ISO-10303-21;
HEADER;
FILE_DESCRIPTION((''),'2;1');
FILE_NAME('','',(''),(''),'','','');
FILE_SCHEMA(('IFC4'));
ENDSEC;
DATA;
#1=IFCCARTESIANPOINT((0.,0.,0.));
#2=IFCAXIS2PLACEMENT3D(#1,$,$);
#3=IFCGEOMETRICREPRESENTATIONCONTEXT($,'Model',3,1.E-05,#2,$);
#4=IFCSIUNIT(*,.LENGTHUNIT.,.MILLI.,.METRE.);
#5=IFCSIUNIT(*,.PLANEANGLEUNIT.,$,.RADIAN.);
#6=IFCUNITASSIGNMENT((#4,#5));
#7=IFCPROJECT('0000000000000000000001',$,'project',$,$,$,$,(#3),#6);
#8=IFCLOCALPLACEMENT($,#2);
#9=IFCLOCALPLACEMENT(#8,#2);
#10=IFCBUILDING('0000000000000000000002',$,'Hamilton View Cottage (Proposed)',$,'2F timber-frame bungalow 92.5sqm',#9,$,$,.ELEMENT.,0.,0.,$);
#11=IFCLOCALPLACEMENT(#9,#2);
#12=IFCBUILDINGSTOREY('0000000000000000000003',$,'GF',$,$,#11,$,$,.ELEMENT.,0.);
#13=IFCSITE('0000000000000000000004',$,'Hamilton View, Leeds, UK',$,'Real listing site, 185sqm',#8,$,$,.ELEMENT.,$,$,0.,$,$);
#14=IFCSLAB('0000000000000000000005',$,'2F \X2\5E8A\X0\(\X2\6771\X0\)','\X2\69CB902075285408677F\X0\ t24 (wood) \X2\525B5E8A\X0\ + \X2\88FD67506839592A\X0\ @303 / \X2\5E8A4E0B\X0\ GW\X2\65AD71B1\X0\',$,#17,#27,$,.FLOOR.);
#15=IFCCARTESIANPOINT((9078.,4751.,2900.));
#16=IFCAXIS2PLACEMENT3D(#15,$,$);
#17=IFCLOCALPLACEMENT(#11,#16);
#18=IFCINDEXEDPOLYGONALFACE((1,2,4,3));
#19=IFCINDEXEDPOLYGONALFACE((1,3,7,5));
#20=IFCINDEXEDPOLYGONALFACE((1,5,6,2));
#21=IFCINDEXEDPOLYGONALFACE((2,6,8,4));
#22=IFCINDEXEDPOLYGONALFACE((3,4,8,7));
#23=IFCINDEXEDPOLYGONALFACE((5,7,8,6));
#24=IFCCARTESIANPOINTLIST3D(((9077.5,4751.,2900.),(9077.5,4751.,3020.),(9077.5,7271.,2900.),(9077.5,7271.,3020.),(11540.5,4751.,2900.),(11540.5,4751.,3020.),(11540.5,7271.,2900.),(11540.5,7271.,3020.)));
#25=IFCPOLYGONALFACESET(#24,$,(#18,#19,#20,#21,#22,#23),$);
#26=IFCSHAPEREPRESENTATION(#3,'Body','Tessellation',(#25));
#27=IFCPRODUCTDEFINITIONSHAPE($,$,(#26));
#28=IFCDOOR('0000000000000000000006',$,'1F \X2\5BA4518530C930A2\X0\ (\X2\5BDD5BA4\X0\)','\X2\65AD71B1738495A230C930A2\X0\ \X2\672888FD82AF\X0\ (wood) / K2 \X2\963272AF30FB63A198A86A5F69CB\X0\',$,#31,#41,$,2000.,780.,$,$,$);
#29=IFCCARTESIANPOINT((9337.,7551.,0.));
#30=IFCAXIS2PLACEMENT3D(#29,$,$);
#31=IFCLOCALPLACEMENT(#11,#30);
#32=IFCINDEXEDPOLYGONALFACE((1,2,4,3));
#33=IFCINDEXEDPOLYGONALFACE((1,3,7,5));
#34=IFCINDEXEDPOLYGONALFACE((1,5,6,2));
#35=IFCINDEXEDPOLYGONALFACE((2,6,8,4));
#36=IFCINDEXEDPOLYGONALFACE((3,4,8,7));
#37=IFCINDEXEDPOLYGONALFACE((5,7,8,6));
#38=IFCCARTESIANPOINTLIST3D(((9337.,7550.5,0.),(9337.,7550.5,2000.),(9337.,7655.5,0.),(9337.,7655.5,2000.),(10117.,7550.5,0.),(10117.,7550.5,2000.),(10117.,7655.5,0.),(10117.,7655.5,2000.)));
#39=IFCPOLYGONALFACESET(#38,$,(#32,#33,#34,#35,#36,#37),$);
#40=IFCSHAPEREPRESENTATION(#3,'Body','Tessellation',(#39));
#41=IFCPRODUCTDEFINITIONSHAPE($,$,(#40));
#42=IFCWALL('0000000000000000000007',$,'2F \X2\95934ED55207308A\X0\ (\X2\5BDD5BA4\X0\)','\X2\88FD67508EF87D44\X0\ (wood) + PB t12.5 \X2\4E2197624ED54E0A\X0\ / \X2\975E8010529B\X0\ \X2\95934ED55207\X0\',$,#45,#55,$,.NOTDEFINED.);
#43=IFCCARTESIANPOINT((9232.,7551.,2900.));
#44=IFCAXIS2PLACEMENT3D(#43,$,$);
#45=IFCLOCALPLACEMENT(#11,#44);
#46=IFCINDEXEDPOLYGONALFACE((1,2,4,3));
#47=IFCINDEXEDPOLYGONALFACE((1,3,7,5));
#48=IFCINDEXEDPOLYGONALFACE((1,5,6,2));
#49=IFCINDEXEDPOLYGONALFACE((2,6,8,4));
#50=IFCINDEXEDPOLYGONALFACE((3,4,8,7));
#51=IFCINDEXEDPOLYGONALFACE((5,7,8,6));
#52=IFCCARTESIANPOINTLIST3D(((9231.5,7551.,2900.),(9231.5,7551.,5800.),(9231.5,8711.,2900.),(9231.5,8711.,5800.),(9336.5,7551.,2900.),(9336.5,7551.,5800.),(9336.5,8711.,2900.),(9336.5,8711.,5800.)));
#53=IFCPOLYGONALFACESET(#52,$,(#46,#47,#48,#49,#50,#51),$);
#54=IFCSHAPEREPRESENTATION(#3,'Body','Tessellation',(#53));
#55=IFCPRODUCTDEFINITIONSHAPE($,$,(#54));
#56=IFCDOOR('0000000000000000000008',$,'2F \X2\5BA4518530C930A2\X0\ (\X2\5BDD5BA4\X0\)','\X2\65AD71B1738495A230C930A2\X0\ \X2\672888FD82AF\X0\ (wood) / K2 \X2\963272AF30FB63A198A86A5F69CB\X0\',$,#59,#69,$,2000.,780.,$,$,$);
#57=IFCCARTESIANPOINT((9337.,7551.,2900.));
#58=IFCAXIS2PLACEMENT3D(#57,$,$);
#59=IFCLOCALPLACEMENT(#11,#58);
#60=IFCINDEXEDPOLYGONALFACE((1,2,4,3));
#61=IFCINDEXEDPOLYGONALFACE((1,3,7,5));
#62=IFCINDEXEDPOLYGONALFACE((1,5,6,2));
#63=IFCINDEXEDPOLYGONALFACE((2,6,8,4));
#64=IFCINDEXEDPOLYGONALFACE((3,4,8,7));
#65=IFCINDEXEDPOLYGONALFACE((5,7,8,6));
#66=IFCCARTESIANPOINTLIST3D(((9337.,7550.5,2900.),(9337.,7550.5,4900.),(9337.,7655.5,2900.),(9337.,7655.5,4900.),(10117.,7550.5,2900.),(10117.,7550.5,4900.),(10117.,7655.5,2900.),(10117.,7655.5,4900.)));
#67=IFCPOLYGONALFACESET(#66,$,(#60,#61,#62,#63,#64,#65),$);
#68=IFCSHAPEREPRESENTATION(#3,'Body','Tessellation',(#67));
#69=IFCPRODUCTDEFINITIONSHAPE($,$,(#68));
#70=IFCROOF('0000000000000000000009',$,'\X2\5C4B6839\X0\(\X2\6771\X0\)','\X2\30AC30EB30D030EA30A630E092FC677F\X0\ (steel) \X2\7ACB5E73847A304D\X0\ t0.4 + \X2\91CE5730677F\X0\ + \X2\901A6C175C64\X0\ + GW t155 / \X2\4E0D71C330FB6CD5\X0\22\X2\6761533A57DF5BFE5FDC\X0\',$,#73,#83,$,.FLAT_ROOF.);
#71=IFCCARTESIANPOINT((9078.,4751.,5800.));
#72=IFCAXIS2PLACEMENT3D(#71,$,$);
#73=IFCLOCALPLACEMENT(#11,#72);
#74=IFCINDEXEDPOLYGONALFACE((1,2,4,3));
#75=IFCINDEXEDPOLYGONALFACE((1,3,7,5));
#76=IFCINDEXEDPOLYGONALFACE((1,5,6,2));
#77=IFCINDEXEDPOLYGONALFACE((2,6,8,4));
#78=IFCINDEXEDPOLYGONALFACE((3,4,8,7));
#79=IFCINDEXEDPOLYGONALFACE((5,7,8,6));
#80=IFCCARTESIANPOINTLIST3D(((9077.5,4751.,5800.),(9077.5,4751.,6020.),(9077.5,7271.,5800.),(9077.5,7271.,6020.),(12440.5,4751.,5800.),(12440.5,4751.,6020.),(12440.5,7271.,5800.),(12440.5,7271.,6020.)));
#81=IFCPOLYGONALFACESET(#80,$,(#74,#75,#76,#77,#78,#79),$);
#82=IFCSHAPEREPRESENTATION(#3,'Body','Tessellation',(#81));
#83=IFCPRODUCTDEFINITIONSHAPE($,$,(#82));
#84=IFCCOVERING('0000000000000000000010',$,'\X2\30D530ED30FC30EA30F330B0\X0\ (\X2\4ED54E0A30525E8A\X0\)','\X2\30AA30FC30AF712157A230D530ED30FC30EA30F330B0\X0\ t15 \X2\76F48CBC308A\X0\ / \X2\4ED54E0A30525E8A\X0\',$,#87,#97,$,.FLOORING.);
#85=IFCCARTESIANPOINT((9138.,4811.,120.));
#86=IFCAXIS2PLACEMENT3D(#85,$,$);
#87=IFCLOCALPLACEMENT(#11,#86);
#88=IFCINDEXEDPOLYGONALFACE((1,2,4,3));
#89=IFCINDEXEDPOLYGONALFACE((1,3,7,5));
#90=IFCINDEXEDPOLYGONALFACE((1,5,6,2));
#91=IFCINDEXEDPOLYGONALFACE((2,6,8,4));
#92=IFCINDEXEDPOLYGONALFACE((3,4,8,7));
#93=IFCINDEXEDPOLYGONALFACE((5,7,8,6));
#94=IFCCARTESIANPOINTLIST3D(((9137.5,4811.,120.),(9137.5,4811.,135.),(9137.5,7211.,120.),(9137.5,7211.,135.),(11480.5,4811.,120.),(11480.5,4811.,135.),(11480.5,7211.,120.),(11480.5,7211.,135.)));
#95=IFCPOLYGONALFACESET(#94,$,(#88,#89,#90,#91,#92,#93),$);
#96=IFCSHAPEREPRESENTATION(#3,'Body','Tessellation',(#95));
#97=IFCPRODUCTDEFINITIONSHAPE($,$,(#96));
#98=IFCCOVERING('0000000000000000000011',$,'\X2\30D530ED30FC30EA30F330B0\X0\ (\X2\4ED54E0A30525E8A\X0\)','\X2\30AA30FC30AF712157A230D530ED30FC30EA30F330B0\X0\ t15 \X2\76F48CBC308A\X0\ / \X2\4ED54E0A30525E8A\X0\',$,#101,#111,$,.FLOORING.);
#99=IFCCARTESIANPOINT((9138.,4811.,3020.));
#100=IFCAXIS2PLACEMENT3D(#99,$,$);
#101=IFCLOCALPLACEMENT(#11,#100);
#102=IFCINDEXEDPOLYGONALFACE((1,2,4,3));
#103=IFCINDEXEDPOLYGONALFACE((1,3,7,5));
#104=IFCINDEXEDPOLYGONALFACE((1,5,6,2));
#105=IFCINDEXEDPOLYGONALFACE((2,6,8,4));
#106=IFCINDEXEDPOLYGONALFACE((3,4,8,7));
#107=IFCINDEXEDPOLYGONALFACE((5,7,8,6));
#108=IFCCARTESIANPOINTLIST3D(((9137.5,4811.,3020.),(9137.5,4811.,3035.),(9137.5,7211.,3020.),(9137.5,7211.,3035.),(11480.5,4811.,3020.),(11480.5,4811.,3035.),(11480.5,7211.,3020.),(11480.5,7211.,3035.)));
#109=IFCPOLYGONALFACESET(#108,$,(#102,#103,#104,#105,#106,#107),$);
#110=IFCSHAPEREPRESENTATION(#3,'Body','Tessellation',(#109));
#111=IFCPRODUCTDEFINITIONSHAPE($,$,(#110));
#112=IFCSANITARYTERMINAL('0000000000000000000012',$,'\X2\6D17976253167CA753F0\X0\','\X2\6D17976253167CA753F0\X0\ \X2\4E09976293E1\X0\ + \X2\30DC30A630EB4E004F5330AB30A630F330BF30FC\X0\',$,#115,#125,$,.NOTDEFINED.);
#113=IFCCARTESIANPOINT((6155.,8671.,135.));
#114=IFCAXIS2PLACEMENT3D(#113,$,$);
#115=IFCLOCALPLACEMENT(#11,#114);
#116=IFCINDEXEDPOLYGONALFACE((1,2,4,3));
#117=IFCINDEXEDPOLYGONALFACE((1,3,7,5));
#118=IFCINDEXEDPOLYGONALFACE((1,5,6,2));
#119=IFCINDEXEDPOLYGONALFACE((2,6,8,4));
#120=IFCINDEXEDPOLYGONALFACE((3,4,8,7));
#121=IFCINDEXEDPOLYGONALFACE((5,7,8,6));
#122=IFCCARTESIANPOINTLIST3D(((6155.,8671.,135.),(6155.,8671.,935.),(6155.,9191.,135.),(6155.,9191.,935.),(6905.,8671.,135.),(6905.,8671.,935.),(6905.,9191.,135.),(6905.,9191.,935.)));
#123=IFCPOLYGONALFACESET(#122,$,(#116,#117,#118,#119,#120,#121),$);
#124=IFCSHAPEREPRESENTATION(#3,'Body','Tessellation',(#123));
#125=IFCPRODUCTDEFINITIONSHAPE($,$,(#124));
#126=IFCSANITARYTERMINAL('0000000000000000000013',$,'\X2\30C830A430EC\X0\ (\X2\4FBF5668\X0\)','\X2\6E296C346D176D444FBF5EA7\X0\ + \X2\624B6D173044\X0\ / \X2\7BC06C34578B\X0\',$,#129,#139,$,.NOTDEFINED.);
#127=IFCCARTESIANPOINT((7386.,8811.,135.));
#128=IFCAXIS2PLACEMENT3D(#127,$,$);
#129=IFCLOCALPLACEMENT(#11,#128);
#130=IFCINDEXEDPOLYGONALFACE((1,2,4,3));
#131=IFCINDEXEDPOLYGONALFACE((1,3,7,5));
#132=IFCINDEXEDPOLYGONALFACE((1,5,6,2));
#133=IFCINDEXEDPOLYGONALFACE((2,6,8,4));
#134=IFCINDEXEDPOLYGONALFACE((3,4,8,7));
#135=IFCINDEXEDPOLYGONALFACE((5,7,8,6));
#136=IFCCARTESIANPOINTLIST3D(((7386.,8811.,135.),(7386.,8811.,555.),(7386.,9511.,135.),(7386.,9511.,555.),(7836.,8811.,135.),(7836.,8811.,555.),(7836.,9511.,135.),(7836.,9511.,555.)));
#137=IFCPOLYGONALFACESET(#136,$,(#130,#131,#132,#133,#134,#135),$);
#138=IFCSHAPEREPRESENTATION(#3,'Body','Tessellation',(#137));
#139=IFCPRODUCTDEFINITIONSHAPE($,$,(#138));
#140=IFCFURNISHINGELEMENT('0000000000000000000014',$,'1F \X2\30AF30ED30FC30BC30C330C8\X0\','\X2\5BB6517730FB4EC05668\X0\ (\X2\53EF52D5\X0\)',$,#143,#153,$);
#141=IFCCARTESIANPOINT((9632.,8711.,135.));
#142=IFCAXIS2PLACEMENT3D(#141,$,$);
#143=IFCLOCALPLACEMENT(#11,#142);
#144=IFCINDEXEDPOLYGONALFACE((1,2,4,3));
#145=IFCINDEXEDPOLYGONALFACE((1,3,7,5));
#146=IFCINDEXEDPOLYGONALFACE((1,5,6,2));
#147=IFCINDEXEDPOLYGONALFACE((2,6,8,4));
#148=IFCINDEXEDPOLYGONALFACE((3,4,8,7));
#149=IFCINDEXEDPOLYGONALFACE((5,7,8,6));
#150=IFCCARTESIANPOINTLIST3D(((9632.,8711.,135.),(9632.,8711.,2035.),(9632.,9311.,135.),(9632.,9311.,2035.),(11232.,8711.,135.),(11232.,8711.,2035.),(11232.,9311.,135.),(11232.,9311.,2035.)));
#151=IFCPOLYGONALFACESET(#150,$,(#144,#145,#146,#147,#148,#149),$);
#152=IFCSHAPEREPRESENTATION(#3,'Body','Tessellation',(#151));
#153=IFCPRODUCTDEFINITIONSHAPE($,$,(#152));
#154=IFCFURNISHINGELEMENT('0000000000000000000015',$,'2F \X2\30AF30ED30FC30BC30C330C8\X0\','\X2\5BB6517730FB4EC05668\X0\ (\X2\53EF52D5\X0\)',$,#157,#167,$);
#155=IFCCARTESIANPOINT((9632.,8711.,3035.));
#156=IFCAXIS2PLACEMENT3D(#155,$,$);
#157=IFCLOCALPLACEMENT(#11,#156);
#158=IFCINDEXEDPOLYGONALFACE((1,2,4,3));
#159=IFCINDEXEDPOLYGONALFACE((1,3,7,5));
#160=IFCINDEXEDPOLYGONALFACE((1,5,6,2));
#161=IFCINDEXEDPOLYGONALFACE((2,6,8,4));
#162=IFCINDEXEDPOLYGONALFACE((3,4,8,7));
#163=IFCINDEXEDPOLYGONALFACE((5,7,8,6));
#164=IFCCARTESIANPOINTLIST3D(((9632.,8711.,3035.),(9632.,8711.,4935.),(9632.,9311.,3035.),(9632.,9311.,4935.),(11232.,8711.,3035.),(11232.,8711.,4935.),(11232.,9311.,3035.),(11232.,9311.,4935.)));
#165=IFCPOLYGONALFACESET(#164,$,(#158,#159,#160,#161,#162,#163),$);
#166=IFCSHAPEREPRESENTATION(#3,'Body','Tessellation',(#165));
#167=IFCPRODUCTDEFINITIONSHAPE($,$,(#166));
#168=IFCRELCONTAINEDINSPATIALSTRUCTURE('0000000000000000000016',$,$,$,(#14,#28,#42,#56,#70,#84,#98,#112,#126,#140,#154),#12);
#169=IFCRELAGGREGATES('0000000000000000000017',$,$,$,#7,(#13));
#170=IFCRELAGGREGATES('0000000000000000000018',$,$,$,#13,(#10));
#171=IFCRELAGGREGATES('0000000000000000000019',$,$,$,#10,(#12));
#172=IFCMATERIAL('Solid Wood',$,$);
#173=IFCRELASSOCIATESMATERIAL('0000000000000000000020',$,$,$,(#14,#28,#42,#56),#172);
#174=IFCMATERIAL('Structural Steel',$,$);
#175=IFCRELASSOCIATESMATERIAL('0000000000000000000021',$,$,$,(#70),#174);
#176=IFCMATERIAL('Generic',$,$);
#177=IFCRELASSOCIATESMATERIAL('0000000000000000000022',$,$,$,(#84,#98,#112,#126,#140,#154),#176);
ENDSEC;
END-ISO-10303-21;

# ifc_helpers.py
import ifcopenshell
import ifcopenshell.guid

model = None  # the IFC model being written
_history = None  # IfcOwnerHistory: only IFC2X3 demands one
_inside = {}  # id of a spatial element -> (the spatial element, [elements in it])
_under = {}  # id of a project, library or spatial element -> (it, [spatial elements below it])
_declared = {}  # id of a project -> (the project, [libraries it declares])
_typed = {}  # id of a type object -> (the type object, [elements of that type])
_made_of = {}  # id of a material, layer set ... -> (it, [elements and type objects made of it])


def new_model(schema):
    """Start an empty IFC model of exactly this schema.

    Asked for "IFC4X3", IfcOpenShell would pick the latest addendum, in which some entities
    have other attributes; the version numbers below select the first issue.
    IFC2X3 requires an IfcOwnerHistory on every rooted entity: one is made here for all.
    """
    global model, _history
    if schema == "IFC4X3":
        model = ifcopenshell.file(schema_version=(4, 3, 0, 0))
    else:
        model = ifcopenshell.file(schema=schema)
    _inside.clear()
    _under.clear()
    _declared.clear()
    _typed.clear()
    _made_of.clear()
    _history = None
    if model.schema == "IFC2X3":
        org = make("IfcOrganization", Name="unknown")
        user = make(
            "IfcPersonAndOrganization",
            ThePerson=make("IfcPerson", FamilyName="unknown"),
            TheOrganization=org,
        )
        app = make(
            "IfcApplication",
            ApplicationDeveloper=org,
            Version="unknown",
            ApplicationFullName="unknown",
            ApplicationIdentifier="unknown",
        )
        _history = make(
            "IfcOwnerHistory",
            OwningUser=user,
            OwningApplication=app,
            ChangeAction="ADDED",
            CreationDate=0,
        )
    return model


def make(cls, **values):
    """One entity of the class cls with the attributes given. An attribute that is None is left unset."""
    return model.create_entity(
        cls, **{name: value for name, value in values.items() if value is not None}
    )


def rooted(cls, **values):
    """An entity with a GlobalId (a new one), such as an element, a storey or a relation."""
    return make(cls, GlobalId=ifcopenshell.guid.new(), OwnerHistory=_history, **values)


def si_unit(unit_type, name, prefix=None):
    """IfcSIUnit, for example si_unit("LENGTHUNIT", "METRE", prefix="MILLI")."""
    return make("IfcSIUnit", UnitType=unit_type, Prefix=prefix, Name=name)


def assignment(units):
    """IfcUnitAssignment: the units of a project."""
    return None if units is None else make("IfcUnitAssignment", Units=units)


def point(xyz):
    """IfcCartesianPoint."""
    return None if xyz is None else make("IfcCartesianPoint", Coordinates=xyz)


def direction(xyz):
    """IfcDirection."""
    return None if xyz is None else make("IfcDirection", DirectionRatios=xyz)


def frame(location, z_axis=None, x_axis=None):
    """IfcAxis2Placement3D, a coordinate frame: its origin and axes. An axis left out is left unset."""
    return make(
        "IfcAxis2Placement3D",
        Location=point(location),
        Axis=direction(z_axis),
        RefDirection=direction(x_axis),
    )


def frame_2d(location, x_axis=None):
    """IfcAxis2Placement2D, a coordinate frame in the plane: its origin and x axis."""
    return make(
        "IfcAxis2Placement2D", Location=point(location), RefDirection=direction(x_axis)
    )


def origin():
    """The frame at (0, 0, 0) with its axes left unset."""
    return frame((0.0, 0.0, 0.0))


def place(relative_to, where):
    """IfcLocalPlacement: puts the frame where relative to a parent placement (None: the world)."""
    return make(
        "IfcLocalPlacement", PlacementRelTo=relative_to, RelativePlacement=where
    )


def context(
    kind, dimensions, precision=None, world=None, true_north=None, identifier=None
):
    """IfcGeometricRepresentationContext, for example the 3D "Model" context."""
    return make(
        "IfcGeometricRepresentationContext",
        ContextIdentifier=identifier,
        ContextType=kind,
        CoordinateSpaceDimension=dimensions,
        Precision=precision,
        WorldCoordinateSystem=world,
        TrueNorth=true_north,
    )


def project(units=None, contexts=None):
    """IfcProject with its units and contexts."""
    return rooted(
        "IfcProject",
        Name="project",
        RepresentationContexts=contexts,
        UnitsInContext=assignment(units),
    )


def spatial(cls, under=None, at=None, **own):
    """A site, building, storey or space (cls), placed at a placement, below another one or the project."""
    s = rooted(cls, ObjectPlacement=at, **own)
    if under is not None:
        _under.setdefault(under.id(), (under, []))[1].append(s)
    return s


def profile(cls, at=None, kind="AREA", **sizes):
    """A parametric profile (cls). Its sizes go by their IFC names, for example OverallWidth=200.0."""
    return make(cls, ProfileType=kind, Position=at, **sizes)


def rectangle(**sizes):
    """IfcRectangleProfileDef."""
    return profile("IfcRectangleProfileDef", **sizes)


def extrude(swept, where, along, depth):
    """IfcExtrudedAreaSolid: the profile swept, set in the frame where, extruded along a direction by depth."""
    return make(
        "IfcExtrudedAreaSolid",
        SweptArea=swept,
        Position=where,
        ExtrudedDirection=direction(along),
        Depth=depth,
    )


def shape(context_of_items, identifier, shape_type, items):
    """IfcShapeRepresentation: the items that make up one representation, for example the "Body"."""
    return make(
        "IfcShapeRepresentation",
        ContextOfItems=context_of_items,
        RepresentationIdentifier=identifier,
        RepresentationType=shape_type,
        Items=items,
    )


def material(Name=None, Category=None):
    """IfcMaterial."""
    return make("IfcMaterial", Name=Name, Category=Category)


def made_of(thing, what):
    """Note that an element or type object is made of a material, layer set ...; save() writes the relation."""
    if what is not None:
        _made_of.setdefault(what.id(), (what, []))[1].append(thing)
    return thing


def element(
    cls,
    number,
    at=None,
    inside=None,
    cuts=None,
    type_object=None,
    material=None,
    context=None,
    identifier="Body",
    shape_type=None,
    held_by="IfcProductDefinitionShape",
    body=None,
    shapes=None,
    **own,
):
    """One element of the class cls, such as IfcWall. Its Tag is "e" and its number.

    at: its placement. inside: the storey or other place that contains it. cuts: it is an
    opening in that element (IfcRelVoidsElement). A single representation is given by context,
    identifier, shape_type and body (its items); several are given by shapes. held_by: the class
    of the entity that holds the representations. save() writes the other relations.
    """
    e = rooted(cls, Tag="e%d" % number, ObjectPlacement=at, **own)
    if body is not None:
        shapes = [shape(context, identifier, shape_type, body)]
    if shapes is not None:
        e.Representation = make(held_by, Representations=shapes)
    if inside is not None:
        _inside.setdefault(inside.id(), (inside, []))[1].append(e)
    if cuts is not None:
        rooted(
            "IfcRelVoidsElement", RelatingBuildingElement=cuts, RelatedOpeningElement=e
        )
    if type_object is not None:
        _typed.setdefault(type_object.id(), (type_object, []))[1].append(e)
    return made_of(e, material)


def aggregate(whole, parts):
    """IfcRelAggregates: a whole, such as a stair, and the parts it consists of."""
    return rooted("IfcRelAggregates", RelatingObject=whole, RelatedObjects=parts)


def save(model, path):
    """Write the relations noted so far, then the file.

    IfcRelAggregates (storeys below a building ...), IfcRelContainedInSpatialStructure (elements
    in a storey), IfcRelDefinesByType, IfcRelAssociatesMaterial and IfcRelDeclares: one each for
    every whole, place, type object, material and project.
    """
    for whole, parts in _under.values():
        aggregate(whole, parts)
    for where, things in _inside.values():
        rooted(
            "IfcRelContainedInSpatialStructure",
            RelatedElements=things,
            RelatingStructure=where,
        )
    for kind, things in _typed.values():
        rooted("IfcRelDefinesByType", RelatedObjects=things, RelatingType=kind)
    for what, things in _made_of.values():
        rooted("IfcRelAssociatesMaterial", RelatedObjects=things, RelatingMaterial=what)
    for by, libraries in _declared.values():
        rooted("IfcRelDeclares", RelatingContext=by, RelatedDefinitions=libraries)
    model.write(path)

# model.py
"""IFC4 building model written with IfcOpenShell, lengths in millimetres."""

from ifc_helpers import new_model, si_unit, frame, frame_2d, origin, place, context, project, spatial, rectangle, extrude, material, element, save


model = new_model("IFC4")

# Units and contexts
model_context = context("Model", 3, precision=1e-05, world=origin())
ifc_project = project(units=[si_unit("LENGTHUNIT", "METRE", prefix="MILLI"), si_unit("PLANEANGLEUNIT", "RADIAN")], contexts=[model_context])

# Site, building, storey
site_placement = place(None, origin())
site = spatial("IfcSite", under=ifc_project, at=site_placement, Name="Hamilton View, Leeds, UK", ObjectType="Real listing site, 185sqm", CompositionType="ELEMENT", RefElevation=0.0)
building_placement = place(site_placement, origin())
building = spatial("IfcBuilding", under=site, at=building_placement, Name="Hamilton View Cottage (Proposed)", ObjectType="2F timber-frame bungalow 92.5sqm", CompositionType="ELEMENT", ElevationOfRefHeight=0.0, ElevationOfTerrain=0.0)
storey_placement = place(building_placement, origin())
storey = spatial("IfcBuildingStorey", under=building, at=storey_placement, Name="GF", CompositionType="ELEMENT", Elevation=0.0)

# Slab
ifc_material_1 = material(Name="Solid Wood")
slab_1_placement = place(storey_placement, frame((9078.0, 4751.0, 2900.0)))
element("IfcSlab", 1, at=slab_1_placement, inside=storey, material=ifc_material_1, Name="2F 床(東)", Description="構造用合板 t24 (wood) 剛床 + 製材根太 @303 / 床下 GW断熱", PredefinedType="FLOOR", context=model_context, shape_type="SweptSolid", body=[
    extrude(rectangle(XDim=2463.0, YDim=2520.0, at=frame_2d((1231.0, 1260.0))), frame((9078.0, 4751.0, 2900.0)), (0.0, 0.0, 1.0), 120.0),
])

# Door
door_1_placement = place(storey_placement, frame((9337.0, 7551.0, 0.0)))
element("IfcDoor", 2, at=door_1_placement, inside=storey, material=ifc_material_1, Name="1F 室内ドア (寝室)", Description="断熱玄関ドア 木製芯 (wood) / K2 防犯・採風機構", OverallHeight=2000.0, OverallWidth=780.0, context=model_context, shape_type="SweptSolid", body=[
    extrude(rectangle(XDim=780.0, YDim=105.0, at=frame_2d((390.0, 52.0))), frame((9337.0, 7551.0, 0.0)), (0.0, 0.0, 1.0), 2000.0),
])

# Wall
wall_1_placement = place(storey_placement, frame((9232.0, 7551.0, 2900.0)))
element("IfcWall", 3, at=wall_1_placement, inside=storey, material=ifc_material_1, Name="2F 間仕切り (寝室)", Description="製材軸組 (wood) + PB t12.5 両面仕上 / 非耐力 間仕切", PredefinedType="NOTDEFINED", context=model_context, shape_type="SweptSolid", body=[
    extrude(rectangle(XDim=105.0, YDim=1160.0, at=frame_2d((52.0, 580.0))), frame((9232.0, 7551.0, 2900.0)), (0.0, 0.0, 1.0), 2900.0),
])

# Door
door_2_placement = place(storey_placement, frame((9337.0, 7551.0, 2900.0)))
element("IfcDoor", 4, at=door_2_placement, inside=storey, material=ifc_material_1, Name="2F 室内ドア (寝室)", Description="断熱玄関ドア 木製芯 (wood) / K2 防犯・採風機構", OverallHeight=2000.0, OverallWidth=780.0, context=model_context, shape_type="SweptSolid", body=[
    extrude(rectangle(XDim=780.0, YDim=105.0, at=frame_2d((390.0, 52.0))), frame((9337.0, 7551.0, 2900.0)), (0.0, 0.0, 1.0), 2000.0),
])

# Roof
ifc_material_2 = material(Name="Structural Steel")
for number, where, name in (
    (5, (9078.0, 4751.0, 5800.0), "屋根(東)"),
):
    element("IfcRoof", number, at=place(storey_placement, frame(where)), inside=storey, material=ifc_material_2, Name=name, Description="ガルバリウム鋼板 (steel) 立平葺き t0.4 + 野地板 + 通気層 + GW t155 / 不燃・法22条区域対応", PredefinedType="FLAT_ROOF", context=model_context, shape_type="SweptSolid", body=[
        extrude(rectangle(XDim=3363.0, YDim=2520.0, at=frame_2d((1681.0, 1260.0))), frame((9078.0, 4751.0, 5800.0)), (0.0, 0.0, 1.0), 220.0),
    ])

# Coverings
ifc_material_3 = material(Name="Generic")
covering_1_placement = place(storey_placement, frame((9138.0, 4811.0, 120.0)))
element("IfcCovering", 6, at=covering_1_placement, inside=storey, material=ifc_material_3, Name="フローリング (仕上げ床)", Description="オーク無垢フローリング t15 直貼り / 仕上げ床", PredefinedType="FLOORING", context=model_context, shape_type="SweptSolid", body=[
    extrude(rectangle(XDim=2343.0, YDim=2400.0, at=frame_2d((1171.0, 1200.0))), frame((9138.0, 4811.0, 120.0)), (0.0, 0.0, 1.0), 15.0),
])
covering_2_placement = place(storey_placement, frame((9138.0, 4811.0, 3020.0)))
element("IfcCovering", 7, at=covering_2_placement, inside=storey, material=ifc_material_3, Name="フローリング (仕上げ床)", Description="オーク無垢フローリング t15 直貼り / 仕上げ床", PredefinedType="FLOORING", context=model_context, shape_type="SweptSolid", body=[
    extrude(rectangle(XDim=2343.0, YDim=2400.0, at=frame_2d((1171.0, 1200.0))), frame((9138.0, 4811.0, 3020.0)), (0.0, 0.0, 1.0), 15.0),
])

# Sanitary terminals
sanitary_terminal_1_placement = place(storey_placement, frame((6155.0, 8671.0, 135.0)))
element("IfcSanitaryTerminal", 8, at=sanitary_terminal_1_placement, inside=storey, material=ifc_material_3, Name="洗面化粧台", Description="洗面化粧台 三面鏡 + ボウル一体カウンター", PredefinedType="NOTDEFINED", context=model_context, shape_type="SweptSolid", body=[
    extrude(rectangle(XDim=750.0, YDim=520.0, at=frame_2d((375.0, 260.0))), frame((6155.0, 8671.0, 135.0)), (0.0, 0.0, 1.0), 800.0),
])
sanitary_terminal_2_placement = place(storey_placement, frame((7386.0, 8811.0, 135.0)))
element("IfcSanitaryTerminal", 9, at=sanitary_terminal_2_placement, inside=storey, material=ifc_material_3, Name="トイレ (便器)", Description="温水洗浄便座 + 手洗い / 節水型", PredefinedType="NOTDEFINED", context=model_context, shape_type="SweptSolid", body=[
    extrude(rectangle(XDim=450.0, YDim=700.0, at=frame_2d((225.0, 350.0))), frame((7386.0, 8811.0, 135.0)), (0.0, 0.0, 1.0), 420.0),
])

# Furnishing elements
furnishing_1_placement = place(storey_placement, frame((9632.0, 8711.0, 135.0)))
element("IfcFurnishingElement", 10, at=furnishing_1_placement, inside=storey, material=ifc_material_3, Name="1F クローゼット", Description="家具・什器 (可動)", context=model_context, shape_type="SweptSolid", body=[
    extrude(rectangle(XDim=1600.0, YDim=600.0, at=frame_2d((800.0, 300.0))), frame((9632.0, 8711.0, 135.0)), (0.0, 0.0, 1.0), 1900.0),
])
furnishing_2_placement = place(storey_placement, frame((9632.0, 8711.0, 3035.0)))
element("IfcFurnishingElement", 11, at=furnishing_2_placement, inside=storey, material=ifc_material_3, Name="2F クローゼット", Description="家具・什器 (可動)", context=model_context, shape_type="SweptSolid", body=[
    extrude(rectangle(XDim=1600.0, YDim=600.0, at=frame_2d((800.0, 300.0))), frame((9632.0, 8711.0, 3035.0)), (0.0, 0.0, 1.0), 1900.0),
])

save(model, "model.ifc")
